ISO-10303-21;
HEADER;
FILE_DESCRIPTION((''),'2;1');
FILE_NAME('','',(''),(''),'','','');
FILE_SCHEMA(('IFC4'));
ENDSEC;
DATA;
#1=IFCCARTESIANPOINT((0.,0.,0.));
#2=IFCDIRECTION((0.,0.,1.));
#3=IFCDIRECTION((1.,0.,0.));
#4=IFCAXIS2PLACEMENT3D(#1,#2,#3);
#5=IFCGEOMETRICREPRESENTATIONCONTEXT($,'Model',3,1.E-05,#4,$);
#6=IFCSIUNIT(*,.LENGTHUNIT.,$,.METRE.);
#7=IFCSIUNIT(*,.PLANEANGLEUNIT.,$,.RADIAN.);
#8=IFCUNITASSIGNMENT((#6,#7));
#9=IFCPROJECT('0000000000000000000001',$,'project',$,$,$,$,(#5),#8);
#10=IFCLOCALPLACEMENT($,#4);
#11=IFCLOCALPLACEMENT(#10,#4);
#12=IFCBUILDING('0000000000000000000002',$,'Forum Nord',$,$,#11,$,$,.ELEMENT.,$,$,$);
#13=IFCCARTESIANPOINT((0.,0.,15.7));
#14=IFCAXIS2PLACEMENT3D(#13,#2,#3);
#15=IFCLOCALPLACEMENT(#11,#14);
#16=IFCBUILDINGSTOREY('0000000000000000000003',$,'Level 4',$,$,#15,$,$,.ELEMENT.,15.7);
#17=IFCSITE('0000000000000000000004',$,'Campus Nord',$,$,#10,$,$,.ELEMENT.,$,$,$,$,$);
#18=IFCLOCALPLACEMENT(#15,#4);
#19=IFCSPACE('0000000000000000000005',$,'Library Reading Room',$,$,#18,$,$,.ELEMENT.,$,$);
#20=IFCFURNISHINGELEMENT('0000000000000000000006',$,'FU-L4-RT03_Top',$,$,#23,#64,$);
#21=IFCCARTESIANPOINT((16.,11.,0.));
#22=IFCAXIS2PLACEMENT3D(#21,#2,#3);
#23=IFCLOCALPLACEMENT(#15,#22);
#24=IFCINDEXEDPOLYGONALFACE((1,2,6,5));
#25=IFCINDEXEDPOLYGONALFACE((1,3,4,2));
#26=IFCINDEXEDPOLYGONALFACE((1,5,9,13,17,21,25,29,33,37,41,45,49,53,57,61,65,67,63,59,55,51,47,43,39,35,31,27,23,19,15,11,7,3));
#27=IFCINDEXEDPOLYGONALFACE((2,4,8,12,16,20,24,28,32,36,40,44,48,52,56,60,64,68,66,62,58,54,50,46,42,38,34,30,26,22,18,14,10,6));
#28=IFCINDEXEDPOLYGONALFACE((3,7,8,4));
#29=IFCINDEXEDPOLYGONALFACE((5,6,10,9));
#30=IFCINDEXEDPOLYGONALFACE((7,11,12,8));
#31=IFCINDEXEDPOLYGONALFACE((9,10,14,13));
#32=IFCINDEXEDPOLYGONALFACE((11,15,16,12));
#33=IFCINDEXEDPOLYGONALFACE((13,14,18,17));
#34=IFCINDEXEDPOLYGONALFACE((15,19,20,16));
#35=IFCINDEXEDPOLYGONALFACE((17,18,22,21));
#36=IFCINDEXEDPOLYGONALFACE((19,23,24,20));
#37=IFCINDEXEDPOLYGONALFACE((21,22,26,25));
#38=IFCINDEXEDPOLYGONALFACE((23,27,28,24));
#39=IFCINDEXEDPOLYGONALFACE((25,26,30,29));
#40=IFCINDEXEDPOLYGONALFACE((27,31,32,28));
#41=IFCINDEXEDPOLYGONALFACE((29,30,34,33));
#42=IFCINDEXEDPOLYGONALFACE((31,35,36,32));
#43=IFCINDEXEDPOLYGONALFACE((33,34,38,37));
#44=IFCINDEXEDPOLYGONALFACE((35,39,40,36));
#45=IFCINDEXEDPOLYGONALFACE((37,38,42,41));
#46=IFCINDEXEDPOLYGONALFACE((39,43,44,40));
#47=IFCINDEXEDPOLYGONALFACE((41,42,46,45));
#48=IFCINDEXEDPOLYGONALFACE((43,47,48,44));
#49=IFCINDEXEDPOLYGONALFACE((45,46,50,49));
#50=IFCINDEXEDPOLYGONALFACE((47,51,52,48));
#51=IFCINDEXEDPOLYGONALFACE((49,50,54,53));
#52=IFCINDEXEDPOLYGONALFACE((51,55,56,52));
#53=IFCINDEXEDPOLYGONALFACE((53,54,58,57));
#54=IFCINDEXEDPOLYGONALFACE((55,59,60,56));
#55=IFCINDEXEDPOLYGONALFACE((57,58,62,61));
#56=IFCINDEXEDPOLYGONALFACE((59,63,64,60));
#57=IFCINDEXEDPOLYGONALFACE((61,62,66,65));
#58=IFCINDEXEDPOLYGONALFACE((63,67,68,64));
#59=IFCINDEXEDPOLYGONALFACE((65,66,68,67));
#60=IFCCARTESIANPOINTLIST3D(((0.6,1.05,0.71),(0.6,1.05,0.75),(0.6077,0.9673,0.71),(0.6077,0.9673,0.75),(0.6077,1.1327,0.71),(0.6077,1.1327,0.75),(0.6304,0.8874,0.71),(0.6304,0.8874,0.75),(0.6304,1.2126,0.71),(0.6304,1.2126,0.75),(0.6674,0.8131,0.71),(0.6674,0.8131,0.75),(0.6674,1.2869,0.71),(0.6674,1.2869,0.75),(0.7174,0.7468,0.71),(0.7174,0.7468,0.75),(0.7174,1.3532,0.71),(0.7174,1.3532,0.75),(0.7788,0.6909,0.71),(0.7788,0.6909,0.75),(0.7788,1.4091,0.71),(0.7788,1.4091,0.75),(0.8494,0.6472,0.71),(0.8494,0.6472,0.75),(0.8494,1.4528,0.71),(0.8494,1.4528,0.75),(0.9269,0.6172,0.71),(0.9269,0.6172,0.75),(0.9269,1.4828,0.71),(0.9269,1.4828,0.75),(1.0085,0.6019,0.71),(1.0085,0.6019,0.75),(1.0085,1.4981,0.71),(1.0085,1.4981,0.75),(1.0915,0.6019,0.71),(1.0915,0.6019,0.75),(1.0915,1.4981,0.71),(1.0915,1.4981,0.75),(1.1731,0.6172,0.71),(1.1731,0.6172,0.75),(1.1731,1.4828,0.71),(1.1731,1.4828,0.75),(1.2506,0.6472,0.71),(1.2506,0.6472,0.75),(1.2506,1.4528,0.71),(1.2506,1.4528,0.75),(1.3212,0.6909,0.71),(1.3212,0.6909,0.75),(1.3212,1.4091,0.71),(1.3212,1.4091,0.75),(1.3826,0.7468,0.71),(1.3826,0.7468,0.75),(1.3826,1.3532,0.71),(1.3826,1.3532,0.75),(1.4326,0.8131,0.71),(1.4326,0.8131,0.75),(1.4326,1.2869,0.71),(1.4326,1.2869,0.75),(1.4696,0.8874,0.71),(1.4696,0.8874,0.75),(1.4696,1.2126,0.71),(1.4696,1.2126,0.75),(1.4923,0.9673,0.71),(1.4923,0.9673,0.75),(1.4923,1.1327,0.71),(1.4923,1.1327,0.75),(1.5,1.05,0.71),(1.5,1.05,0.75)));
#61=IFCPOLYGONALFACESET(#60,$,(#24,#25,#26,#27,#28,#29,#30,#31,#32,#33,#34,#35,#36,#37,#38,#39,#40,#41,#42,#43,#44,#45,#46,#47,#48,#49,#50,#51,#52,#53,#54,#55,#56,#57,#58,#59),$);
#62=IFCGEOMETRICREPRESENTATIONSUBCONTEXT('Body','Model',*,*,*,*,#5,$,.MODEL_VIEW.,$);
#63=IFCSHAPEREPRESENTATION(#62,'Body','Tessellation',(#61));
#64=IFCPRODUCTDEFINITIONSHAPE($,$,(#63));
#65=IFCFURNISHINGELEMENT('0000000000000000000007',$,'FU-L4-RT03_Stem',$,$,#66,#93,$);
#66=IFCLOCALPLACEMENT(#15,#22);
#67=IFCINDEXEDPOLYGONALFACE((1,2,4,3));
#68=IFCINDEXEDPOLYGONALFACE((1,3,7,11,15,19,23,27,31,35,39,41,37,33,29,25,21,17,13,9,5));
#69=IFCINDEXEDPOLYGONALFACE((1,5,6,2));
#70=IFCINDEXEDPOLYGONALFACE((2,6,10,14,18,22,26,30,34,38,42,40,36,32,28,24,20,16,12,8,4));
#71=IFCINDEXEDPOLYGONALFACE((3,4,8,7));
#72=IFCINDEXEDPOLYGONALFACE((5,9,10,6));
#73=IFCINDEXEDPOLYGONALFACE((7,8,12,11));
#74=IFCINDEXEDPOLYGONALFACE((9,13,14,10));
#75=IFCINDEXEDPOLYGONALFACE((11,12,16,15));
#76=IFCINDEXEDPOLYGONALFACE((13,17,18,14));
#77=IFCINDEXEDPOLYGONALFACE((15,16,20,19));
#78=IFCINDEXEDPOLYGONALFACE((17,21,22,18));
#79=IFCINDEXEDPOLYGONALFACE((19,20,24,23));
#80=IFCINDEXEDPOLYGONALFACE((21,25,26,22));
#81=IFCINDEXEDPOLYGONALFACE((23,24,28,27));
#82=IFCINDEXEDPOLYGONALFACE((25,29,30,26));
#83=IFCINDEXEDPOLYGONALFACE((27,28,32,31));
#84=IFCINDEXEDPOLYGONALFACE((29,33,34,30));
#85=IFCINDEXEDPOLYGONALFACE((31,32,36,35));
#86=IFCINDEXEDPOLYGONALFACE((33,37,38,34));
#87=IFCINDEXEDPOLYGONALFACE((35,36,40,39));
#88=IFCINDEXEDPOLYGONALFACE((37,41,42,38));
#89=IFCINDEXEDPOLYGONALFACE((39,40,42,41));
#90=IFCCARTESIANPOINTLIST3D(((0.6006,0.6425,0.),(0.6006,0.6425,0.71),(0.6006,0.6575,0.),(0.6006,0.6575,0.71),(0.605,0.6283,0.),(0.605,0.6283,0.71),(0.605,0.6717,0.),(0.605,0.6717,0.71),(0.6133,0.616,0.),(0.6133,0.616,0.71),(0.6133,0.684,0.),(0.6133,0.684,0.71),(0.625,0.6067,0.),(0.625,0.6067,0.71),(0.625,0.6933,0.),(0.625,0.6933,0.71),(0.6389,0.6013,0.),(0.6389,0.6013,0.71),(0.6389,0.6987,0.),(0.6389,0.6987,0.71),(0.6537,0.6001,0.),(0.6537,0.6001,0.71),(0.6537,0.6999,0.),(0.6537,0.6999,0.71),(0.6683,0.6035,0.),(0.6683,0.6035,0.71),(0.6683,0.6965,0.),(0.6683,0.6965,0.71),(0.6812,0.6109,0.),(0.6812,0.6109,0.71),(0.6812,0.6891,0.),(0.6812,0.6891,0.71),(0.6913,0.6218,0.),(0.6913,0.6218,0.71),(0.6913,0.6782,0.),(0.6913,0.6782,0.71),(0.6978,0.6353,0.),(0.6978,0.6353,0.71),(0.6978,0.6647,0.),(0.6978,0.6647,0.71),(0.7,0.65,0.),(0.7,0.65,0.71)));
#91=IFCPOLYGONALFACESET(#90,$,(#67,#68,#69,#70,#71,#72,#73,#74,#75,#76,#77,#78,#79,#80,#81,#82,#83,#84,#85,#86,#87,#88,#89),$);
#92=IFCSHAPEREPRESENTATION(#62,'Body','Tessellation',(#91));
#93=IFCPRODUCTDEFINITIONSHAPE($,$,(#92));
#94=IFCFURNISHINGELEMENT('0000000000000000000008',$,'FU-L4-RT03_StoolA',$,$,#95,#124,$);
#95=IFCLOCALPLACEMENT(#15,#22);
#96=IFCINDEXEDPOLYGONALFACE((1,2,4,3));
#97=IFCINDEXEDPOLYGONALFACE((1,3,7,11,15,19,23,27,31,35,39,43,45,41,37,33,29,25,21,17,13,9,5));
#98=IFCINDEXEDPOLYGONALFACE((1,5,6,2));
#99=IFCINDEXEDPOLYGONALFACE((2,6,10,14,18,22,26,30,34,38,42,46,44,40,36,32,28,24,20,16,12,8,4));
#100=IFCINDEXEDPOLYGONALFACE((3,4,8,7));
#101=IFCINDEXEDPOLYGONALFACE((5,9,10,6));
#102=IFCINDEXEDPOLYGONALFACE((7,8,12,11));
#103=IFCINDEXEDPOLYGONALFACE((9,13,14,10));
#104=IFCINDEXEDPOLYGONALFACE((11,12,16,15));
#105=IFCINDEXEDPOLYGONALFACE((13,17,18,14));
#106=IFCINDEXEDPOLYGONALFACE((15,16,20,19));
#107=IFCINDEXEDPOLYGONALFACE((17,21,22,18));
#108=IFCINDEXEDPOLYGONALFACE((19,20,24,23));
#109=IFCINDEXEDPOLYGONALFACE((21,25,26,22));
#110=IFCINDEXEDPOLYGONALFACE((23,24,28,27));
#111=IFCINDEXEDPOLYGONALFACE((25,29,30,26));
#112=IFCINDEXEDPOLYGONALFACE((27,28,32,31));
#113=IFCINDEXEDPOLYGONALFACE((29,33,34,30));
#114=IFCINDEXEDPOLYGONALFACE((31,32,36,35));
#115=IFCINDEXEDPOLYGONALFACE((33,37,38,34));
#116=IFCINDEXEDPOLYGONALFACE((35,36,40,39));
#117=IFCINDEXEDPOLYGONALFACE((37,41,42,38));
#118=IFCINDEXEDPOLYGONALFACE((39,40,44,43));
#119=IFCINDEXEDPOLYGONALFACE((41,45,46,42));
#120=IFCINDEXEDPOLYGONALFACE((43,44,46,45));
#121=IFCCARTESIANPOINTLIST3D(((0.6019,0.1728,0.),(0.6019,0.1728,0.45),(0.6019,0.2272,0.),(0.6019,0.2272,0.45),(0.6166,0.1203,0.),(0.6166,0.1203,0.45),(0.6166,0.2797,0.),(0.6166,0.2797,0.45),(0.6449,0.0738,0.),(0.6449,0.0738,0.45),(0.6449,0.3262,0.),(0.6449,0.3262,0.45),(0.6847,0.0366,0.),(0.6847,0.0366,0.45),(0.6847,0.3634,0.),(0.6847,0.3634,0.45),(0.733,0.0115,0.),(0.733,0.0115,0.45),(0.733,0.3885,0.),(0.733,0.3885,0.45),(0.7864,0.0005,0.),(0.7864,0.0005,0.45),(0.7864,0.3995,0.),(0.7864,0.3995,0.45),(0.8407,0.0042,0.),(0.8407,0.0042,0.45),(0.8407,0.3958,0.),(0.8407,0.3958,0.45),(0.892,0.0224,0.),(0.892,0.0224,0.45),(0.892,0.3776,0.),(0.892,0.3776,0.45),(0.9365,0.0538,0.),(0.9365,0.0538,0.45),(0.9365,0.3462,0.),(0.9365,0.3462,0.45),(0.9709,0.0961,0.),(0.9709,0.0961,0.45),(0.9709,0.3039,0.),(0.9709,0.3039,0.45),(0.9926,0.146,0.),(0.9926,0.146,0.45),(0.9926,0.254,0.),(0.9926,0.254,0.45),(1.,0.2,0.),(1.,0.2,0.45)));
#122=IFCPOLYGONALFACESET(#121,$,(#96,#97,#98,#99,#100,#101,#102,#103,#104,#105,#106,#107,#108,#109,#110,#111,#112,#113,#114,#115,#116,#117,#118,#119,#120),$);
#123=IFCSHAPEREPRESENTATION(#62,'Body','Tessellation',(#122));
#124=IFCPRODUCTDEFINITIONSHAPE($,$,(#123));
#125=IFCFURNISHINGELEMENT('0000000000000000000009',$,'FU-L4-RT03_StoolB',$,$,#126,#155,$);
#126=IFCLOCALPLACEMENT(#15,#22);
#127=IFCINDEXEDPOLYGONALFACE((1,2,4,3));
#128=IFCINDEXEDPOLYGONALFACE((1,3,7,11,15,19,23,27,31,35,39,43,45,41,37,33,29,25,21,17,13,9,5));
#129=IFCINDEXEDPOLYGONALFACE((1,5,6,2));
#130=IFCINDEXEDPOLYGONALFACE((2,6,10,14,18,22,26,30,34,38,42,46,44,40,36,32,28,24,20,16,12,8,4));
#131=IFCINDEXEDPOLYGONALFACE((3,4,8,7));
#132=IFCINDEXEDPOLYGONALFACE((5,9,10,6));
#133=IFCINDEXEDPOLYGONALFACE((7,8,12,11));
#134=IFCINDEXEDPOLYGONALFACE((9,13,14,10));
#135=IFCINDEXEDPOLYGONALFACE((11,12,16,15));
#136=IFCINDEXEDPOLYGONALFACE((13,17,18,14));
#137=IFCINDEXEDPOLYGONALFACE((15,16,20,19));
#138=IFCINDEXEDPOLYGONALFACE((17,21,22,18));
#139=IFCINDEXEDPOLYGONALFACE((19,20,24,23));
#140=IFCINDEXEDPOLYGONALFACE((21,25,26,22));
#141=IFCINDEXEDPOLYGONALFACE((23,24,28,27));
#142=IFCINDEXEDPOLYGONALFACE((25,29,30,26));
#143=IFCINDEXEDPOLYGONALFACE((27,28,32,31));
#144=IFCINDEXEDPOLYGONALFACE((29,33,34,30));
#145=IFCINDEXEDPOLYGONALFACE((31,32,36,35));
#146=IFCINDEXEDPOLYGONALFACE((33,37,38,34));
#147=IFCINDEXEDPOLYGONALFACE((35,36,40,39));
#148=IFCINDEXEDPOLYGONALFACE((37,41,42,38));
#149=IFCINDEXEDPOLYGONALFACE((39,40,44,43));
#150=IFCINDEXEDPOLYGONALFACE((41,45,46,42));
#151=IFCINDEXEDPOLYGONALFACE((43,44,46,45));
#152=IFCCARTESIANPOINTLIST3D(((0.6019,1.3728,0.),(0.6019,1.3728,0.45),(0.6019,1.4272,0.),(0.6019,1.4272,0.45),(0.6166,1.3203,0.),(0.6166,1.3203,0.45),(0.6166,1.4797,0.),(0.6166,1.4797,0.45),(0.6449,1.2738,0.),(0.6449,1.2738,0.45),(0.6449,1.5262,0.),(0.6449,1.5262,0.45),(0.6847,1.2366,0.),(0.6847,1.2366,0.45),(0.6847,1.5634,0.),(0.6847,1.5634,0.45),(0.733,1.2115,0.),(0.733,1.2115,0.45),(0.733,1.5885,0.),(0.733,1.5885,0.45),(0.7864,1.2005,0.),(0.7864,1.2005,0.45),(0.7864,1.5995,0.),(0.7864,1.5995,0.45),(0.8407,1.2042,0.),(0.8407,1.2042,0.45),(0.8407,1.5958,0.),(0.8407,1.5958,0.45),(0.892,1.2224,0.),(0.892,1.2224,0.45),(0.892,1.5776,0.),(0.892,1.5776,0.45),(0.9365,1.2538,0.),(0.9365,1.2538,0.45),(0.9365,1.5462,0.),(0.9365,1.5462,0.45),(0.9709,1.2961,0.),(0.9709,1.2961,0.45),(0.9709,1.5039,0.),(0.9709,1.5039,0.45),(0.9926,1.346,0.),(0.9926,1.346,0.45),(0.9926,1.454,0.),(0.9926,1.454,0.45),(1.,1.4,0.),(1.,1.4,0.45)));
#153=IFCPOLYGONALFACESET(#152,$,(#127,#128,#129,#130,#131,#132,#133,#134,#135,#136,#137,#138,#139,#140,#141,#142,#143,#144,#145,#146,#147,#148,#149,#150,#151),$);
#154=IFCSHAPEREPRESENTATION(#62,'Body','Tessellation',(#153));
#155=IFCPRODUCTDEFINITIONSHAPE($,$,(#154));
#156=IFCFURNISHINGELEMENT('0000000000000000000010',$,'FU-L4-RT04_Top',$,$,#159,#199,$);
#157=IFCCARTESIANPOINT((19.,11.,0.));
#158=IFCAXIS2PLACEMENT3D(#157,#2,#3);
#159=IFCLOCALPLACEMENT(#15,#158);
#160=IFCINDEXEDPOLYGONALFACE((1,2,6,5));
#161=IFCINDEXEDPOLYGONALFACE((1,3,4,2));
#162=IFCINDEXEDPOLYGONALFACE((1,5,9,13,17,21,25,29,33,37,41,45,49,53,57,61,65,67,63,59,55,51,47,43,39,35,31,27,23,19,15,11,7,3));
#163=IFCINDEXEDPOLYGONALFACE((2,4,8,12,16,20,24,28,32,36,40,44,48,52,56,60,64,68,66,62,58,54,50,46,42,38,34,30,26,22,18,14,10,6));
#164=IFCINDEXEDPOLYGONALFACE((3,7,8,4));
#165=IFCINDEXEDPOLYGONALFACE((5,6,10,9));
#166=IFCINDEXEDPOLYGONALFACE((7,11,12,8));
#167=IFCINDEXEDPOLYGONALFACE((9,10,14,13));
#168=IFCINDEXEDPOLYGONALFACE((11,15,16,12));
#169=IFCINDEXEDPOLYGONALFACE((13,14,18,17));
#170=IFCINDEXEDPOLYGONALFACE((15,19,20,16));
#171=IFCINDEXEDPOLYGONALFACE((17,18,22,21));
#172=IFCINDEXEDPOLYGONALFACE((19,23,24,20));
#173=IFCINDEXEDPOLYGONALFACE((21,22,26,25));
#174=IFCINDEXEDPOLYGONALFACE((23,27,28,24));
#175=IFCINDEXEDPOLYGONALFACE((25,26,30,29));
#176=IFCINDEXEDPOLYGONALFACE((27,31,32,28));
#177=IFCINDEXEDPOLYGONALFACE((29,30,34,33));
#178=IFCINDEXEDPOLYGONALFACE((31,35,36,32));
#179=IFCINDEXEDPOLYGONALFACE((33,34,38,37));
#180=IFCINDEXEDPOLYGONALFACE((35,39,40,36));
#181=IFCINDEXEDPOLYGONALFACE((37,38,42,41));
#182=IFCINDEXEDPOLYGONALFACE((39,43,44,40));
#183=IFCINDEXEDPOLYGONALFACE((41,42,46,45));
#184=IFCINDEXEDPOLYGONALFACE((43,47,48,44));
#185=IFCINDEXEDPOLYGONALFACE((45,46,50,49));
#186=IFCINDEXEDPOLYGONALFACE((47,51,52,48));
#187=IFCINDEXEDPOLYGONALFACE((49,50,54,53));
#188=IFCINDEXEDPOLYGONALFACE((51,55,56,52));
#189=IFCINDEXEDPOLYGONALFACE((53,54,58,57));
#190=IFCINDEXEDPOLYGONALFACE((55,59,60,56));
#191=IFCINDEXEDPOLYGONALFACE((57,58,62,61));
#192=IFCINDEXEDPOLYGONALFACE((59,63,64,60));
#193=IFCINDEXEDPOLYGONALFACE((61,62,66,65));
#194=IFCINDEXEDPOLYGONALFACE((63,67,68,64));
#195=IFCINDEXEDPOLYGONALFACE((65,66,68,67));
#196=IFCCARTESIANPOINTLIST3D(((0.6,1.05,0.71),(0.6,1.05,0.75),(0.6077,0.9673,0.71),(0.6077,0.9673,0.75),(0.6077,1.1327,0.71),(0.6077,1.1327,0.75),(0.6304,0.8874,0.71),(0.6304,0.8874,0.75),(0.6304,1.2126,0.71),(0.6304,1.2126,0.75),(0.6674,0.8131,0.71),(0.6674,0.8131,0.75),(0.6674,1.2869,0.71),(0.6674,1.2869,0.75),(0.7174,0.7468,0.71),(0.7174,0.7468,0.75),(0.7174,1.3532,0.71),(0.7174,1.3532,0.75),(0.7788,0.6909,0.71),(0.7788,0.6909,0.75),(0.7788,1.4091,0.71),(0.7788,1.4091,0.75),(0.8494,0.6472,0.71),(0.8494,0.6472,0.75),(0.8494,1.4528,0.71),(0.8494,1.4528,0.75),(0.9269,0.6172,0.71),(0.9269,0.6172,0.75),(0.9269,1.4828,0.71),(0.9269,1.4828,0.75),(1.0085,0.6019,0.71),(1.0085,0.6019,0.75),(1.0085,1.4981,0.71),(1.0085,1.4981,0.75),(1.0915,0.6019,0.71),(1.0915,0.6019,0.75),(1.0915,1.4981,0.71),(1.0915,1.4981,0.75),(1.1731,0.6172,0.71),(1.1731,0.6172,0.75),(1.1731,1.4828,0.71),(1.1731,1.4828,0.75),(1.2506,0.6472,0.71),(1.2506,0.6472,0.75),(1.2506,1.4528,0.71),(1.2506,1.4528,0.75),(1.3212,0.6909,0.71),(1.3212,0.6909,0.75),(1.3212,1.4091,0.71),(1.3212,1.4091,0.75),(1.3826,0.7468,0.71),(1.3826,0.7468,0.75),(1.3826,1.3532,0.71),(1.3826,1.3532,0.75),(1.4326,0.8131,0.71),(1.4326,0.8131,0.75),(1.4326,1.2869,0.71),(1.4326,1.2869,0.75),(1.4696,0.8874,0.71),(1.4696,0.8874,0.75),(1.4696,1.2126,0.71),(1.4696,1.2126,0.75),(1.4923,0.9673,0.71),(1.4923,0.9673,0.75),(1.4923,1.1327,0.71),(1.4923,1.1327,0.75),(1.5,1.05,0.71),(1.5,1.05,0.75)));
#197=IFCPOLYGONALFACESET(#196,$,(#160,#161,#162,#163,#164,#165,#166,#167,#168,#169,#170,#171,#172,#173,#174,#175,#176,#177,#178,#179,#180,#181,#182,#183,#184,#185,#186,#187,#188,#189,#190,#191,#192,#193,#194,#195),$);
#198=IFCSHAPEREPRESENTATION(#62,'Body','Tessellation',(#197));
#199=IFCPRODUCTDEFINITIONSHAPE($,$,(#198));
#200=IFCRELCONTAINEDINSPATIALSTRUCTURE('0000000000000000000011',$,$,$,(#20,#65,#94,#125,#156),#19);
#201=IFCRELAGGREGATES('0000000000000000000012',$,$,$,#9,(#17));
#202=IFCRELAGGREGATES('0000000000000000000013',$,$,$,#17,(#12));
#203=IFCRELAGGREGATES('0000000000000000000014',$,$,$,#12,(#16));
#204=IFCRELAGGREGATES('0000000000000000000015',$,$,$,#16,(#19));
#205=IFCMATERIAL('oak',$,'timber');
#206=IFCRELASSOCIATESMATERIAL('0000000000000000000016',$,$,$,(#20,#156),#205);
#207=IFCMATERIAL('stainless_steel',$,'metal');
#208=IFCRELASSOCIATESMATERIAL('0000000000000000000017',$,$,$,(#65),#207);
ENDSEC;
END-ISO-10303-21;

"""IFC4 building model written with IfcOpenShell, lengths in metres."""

from ifc_helpers import new_model, si_unit, frame, frame_2d, origin_with_axes, place, context, subcontext, project, spatial, circle, extrude, material, element, save


model = new_model("IFC4")

# Units and contexts
model_context = context("Model", 3, precision=1e-05, world=origin_with_axes())
body_context = subcontext(model_context, "Body", "Model", "MODEL_VIEW")
ifc_project = project(units=[si_unit("LENGTHUNIT", "METRE"), si_unit("PLANEANGLEUNIT", "RADIAN")], contexts=[model_context])

# Site, building, storey
site_placement = place(None, origin_with_axes())
site = spatial("IfcSite", under=ifc_project, at=site_placement, Name="Campus Nord", CompositionType="ELEMENT")
building_placement = place(site_placement, origin_with_axes())
building = spatial("IfcBuilding", under=site, at=building_placement, Name="Forum Nord", CompositionType="ELEMENT")
storey_placement = place(building_placement, frame((0.0, 0.0, 15.7), z_axis=(0.0, 0.0, 1.0), x_axis=(1.0, 0.0, 0.0)))
storey = spatial("IfcBuildingStorey", under=building, at=storey_placement, Name="Level 4", CompositionType="ELEMENT", Elevation=15.7)

# Shared definitions
space_1_placement = place(storey_placement, origin_with_axes())
space_1 = spatial("IfcSpace", under=storey, at=space_1_placement, Name="Library Reading Room", CompositionType="ELEMENT")

# Furnishing elements
ifc_material_1 = material(Name="oak", Category="timber")
furnishing_1_placement = place(storey_placement, frame((16.0, 11.0, 0.0), z_axis=(0.0, 0.0, 1.0), x_axis=(1.0, 0.0, 0.0)))
element("IfcFurnishingElement", 1, at=furnishing_1_placement, inside=space_1, material=ifc_material_1, Name="FU-L4-RT03_Top", context=body_context, shape_type="SweptSolid", body=[
    extrude(circle(Radius=0.45, at=frame_2d((1.05, 1.05), x_axis=(1.0, 0.0))), frame((0.0, 0.0, 0.71), z_axis=(0.0, 0.0, 1.0), x_axis=(1.0, 0.0, 0.0)), (0.0, 0.0, 1.0), 0.04),
])
ifc_material_2 = material(Name="stainless_steel", Category="metal")
furnishing_2_placement = place(storey_placement, frame((16.0, 11.0, 0.0), z_axis=(0.0, 0.0, 1.0), x_axis=(1.0, 0.0, 0.0)))
element("IfcFurnishingElement", 2, at=furnishing_2_placement, inside=space_1, material=ifc_material_2, Name="FU-L4-RT03_Stem", context=body_context, shape_type="SweptSolid", body=[
    extrude(circle(Radius=0.05, at=frame_2d((0.65, 0.65), x_axis=(1.0, 0.0))), origin_with_axes(), (0.0, 0.0, 1.0), 0.71),
])
furnishing_3_placement = place(storey_placement, frame((16.0, 11.0, 0.0), z_axis=(0.0, 0.0, 1.0), x_axis=(1.0, 0.0, 0.0)))
element("IfcFurnishingElement", 3, at=furnishing_3_placement, inside=space_1, Name="FU-L4-RT03_StoolA", context=body_context, shape_type="SweptSolid", body=[
    extrude(circle(Radius=0.2, at=frame_2d((0.8, 0.2), x_axis=(1.0, 0.0))), origin_with_axes(), (0.0, 0.0, 1.0), 0.45),
])
furnishing_4_placement = place(storey_placement, frame((16.0, 11.0, 0.0), z_axis=(0.0, 0.0, 1.0), x_axis=(1.0, 0.0, 0.0)))
element("IfcFurnishingElement", 4, at=furnishing_4_placement, inside=space_1, Name="FU-L4-RT03_StoolB", context=body_context, shape_type="SweptSolid", body=[
    extrude(circle(Radius=0.2, at=frame_2d((0.8, 1.4), x_axis=(1.0, 0.0))), origin_with_axes(), (0.0, 0.0, 1.0), 0.45),
])
furnishing_5_placement = place(storey_placement, frame((19.0, 11.0, 0.0), z_axis=(0.0, 0.0, 1.0), x_axis=(1.0, 0.0, 0.0)))
element("IfcFurnishingElement", 5, at=furnishing_5_placement, inside=space_1, material=ifc_material_1, Name="FU-L4-RT04_Top", context=body_context, shape_type="SweptSolid", body=[
    extrude(circle(Radius=0.45, at=frame_2d((1.05, 1.05), x_axis=(1.0, 0.0))), frame((0.0, 0.0, 0.71), z_axis=(0.0, 0.0, 1.0), x_axis=(1.0, 0.0, 0.0)), (0.0, 0.0, 1.0), 0.04),
])

save(model, "model.ifc")
